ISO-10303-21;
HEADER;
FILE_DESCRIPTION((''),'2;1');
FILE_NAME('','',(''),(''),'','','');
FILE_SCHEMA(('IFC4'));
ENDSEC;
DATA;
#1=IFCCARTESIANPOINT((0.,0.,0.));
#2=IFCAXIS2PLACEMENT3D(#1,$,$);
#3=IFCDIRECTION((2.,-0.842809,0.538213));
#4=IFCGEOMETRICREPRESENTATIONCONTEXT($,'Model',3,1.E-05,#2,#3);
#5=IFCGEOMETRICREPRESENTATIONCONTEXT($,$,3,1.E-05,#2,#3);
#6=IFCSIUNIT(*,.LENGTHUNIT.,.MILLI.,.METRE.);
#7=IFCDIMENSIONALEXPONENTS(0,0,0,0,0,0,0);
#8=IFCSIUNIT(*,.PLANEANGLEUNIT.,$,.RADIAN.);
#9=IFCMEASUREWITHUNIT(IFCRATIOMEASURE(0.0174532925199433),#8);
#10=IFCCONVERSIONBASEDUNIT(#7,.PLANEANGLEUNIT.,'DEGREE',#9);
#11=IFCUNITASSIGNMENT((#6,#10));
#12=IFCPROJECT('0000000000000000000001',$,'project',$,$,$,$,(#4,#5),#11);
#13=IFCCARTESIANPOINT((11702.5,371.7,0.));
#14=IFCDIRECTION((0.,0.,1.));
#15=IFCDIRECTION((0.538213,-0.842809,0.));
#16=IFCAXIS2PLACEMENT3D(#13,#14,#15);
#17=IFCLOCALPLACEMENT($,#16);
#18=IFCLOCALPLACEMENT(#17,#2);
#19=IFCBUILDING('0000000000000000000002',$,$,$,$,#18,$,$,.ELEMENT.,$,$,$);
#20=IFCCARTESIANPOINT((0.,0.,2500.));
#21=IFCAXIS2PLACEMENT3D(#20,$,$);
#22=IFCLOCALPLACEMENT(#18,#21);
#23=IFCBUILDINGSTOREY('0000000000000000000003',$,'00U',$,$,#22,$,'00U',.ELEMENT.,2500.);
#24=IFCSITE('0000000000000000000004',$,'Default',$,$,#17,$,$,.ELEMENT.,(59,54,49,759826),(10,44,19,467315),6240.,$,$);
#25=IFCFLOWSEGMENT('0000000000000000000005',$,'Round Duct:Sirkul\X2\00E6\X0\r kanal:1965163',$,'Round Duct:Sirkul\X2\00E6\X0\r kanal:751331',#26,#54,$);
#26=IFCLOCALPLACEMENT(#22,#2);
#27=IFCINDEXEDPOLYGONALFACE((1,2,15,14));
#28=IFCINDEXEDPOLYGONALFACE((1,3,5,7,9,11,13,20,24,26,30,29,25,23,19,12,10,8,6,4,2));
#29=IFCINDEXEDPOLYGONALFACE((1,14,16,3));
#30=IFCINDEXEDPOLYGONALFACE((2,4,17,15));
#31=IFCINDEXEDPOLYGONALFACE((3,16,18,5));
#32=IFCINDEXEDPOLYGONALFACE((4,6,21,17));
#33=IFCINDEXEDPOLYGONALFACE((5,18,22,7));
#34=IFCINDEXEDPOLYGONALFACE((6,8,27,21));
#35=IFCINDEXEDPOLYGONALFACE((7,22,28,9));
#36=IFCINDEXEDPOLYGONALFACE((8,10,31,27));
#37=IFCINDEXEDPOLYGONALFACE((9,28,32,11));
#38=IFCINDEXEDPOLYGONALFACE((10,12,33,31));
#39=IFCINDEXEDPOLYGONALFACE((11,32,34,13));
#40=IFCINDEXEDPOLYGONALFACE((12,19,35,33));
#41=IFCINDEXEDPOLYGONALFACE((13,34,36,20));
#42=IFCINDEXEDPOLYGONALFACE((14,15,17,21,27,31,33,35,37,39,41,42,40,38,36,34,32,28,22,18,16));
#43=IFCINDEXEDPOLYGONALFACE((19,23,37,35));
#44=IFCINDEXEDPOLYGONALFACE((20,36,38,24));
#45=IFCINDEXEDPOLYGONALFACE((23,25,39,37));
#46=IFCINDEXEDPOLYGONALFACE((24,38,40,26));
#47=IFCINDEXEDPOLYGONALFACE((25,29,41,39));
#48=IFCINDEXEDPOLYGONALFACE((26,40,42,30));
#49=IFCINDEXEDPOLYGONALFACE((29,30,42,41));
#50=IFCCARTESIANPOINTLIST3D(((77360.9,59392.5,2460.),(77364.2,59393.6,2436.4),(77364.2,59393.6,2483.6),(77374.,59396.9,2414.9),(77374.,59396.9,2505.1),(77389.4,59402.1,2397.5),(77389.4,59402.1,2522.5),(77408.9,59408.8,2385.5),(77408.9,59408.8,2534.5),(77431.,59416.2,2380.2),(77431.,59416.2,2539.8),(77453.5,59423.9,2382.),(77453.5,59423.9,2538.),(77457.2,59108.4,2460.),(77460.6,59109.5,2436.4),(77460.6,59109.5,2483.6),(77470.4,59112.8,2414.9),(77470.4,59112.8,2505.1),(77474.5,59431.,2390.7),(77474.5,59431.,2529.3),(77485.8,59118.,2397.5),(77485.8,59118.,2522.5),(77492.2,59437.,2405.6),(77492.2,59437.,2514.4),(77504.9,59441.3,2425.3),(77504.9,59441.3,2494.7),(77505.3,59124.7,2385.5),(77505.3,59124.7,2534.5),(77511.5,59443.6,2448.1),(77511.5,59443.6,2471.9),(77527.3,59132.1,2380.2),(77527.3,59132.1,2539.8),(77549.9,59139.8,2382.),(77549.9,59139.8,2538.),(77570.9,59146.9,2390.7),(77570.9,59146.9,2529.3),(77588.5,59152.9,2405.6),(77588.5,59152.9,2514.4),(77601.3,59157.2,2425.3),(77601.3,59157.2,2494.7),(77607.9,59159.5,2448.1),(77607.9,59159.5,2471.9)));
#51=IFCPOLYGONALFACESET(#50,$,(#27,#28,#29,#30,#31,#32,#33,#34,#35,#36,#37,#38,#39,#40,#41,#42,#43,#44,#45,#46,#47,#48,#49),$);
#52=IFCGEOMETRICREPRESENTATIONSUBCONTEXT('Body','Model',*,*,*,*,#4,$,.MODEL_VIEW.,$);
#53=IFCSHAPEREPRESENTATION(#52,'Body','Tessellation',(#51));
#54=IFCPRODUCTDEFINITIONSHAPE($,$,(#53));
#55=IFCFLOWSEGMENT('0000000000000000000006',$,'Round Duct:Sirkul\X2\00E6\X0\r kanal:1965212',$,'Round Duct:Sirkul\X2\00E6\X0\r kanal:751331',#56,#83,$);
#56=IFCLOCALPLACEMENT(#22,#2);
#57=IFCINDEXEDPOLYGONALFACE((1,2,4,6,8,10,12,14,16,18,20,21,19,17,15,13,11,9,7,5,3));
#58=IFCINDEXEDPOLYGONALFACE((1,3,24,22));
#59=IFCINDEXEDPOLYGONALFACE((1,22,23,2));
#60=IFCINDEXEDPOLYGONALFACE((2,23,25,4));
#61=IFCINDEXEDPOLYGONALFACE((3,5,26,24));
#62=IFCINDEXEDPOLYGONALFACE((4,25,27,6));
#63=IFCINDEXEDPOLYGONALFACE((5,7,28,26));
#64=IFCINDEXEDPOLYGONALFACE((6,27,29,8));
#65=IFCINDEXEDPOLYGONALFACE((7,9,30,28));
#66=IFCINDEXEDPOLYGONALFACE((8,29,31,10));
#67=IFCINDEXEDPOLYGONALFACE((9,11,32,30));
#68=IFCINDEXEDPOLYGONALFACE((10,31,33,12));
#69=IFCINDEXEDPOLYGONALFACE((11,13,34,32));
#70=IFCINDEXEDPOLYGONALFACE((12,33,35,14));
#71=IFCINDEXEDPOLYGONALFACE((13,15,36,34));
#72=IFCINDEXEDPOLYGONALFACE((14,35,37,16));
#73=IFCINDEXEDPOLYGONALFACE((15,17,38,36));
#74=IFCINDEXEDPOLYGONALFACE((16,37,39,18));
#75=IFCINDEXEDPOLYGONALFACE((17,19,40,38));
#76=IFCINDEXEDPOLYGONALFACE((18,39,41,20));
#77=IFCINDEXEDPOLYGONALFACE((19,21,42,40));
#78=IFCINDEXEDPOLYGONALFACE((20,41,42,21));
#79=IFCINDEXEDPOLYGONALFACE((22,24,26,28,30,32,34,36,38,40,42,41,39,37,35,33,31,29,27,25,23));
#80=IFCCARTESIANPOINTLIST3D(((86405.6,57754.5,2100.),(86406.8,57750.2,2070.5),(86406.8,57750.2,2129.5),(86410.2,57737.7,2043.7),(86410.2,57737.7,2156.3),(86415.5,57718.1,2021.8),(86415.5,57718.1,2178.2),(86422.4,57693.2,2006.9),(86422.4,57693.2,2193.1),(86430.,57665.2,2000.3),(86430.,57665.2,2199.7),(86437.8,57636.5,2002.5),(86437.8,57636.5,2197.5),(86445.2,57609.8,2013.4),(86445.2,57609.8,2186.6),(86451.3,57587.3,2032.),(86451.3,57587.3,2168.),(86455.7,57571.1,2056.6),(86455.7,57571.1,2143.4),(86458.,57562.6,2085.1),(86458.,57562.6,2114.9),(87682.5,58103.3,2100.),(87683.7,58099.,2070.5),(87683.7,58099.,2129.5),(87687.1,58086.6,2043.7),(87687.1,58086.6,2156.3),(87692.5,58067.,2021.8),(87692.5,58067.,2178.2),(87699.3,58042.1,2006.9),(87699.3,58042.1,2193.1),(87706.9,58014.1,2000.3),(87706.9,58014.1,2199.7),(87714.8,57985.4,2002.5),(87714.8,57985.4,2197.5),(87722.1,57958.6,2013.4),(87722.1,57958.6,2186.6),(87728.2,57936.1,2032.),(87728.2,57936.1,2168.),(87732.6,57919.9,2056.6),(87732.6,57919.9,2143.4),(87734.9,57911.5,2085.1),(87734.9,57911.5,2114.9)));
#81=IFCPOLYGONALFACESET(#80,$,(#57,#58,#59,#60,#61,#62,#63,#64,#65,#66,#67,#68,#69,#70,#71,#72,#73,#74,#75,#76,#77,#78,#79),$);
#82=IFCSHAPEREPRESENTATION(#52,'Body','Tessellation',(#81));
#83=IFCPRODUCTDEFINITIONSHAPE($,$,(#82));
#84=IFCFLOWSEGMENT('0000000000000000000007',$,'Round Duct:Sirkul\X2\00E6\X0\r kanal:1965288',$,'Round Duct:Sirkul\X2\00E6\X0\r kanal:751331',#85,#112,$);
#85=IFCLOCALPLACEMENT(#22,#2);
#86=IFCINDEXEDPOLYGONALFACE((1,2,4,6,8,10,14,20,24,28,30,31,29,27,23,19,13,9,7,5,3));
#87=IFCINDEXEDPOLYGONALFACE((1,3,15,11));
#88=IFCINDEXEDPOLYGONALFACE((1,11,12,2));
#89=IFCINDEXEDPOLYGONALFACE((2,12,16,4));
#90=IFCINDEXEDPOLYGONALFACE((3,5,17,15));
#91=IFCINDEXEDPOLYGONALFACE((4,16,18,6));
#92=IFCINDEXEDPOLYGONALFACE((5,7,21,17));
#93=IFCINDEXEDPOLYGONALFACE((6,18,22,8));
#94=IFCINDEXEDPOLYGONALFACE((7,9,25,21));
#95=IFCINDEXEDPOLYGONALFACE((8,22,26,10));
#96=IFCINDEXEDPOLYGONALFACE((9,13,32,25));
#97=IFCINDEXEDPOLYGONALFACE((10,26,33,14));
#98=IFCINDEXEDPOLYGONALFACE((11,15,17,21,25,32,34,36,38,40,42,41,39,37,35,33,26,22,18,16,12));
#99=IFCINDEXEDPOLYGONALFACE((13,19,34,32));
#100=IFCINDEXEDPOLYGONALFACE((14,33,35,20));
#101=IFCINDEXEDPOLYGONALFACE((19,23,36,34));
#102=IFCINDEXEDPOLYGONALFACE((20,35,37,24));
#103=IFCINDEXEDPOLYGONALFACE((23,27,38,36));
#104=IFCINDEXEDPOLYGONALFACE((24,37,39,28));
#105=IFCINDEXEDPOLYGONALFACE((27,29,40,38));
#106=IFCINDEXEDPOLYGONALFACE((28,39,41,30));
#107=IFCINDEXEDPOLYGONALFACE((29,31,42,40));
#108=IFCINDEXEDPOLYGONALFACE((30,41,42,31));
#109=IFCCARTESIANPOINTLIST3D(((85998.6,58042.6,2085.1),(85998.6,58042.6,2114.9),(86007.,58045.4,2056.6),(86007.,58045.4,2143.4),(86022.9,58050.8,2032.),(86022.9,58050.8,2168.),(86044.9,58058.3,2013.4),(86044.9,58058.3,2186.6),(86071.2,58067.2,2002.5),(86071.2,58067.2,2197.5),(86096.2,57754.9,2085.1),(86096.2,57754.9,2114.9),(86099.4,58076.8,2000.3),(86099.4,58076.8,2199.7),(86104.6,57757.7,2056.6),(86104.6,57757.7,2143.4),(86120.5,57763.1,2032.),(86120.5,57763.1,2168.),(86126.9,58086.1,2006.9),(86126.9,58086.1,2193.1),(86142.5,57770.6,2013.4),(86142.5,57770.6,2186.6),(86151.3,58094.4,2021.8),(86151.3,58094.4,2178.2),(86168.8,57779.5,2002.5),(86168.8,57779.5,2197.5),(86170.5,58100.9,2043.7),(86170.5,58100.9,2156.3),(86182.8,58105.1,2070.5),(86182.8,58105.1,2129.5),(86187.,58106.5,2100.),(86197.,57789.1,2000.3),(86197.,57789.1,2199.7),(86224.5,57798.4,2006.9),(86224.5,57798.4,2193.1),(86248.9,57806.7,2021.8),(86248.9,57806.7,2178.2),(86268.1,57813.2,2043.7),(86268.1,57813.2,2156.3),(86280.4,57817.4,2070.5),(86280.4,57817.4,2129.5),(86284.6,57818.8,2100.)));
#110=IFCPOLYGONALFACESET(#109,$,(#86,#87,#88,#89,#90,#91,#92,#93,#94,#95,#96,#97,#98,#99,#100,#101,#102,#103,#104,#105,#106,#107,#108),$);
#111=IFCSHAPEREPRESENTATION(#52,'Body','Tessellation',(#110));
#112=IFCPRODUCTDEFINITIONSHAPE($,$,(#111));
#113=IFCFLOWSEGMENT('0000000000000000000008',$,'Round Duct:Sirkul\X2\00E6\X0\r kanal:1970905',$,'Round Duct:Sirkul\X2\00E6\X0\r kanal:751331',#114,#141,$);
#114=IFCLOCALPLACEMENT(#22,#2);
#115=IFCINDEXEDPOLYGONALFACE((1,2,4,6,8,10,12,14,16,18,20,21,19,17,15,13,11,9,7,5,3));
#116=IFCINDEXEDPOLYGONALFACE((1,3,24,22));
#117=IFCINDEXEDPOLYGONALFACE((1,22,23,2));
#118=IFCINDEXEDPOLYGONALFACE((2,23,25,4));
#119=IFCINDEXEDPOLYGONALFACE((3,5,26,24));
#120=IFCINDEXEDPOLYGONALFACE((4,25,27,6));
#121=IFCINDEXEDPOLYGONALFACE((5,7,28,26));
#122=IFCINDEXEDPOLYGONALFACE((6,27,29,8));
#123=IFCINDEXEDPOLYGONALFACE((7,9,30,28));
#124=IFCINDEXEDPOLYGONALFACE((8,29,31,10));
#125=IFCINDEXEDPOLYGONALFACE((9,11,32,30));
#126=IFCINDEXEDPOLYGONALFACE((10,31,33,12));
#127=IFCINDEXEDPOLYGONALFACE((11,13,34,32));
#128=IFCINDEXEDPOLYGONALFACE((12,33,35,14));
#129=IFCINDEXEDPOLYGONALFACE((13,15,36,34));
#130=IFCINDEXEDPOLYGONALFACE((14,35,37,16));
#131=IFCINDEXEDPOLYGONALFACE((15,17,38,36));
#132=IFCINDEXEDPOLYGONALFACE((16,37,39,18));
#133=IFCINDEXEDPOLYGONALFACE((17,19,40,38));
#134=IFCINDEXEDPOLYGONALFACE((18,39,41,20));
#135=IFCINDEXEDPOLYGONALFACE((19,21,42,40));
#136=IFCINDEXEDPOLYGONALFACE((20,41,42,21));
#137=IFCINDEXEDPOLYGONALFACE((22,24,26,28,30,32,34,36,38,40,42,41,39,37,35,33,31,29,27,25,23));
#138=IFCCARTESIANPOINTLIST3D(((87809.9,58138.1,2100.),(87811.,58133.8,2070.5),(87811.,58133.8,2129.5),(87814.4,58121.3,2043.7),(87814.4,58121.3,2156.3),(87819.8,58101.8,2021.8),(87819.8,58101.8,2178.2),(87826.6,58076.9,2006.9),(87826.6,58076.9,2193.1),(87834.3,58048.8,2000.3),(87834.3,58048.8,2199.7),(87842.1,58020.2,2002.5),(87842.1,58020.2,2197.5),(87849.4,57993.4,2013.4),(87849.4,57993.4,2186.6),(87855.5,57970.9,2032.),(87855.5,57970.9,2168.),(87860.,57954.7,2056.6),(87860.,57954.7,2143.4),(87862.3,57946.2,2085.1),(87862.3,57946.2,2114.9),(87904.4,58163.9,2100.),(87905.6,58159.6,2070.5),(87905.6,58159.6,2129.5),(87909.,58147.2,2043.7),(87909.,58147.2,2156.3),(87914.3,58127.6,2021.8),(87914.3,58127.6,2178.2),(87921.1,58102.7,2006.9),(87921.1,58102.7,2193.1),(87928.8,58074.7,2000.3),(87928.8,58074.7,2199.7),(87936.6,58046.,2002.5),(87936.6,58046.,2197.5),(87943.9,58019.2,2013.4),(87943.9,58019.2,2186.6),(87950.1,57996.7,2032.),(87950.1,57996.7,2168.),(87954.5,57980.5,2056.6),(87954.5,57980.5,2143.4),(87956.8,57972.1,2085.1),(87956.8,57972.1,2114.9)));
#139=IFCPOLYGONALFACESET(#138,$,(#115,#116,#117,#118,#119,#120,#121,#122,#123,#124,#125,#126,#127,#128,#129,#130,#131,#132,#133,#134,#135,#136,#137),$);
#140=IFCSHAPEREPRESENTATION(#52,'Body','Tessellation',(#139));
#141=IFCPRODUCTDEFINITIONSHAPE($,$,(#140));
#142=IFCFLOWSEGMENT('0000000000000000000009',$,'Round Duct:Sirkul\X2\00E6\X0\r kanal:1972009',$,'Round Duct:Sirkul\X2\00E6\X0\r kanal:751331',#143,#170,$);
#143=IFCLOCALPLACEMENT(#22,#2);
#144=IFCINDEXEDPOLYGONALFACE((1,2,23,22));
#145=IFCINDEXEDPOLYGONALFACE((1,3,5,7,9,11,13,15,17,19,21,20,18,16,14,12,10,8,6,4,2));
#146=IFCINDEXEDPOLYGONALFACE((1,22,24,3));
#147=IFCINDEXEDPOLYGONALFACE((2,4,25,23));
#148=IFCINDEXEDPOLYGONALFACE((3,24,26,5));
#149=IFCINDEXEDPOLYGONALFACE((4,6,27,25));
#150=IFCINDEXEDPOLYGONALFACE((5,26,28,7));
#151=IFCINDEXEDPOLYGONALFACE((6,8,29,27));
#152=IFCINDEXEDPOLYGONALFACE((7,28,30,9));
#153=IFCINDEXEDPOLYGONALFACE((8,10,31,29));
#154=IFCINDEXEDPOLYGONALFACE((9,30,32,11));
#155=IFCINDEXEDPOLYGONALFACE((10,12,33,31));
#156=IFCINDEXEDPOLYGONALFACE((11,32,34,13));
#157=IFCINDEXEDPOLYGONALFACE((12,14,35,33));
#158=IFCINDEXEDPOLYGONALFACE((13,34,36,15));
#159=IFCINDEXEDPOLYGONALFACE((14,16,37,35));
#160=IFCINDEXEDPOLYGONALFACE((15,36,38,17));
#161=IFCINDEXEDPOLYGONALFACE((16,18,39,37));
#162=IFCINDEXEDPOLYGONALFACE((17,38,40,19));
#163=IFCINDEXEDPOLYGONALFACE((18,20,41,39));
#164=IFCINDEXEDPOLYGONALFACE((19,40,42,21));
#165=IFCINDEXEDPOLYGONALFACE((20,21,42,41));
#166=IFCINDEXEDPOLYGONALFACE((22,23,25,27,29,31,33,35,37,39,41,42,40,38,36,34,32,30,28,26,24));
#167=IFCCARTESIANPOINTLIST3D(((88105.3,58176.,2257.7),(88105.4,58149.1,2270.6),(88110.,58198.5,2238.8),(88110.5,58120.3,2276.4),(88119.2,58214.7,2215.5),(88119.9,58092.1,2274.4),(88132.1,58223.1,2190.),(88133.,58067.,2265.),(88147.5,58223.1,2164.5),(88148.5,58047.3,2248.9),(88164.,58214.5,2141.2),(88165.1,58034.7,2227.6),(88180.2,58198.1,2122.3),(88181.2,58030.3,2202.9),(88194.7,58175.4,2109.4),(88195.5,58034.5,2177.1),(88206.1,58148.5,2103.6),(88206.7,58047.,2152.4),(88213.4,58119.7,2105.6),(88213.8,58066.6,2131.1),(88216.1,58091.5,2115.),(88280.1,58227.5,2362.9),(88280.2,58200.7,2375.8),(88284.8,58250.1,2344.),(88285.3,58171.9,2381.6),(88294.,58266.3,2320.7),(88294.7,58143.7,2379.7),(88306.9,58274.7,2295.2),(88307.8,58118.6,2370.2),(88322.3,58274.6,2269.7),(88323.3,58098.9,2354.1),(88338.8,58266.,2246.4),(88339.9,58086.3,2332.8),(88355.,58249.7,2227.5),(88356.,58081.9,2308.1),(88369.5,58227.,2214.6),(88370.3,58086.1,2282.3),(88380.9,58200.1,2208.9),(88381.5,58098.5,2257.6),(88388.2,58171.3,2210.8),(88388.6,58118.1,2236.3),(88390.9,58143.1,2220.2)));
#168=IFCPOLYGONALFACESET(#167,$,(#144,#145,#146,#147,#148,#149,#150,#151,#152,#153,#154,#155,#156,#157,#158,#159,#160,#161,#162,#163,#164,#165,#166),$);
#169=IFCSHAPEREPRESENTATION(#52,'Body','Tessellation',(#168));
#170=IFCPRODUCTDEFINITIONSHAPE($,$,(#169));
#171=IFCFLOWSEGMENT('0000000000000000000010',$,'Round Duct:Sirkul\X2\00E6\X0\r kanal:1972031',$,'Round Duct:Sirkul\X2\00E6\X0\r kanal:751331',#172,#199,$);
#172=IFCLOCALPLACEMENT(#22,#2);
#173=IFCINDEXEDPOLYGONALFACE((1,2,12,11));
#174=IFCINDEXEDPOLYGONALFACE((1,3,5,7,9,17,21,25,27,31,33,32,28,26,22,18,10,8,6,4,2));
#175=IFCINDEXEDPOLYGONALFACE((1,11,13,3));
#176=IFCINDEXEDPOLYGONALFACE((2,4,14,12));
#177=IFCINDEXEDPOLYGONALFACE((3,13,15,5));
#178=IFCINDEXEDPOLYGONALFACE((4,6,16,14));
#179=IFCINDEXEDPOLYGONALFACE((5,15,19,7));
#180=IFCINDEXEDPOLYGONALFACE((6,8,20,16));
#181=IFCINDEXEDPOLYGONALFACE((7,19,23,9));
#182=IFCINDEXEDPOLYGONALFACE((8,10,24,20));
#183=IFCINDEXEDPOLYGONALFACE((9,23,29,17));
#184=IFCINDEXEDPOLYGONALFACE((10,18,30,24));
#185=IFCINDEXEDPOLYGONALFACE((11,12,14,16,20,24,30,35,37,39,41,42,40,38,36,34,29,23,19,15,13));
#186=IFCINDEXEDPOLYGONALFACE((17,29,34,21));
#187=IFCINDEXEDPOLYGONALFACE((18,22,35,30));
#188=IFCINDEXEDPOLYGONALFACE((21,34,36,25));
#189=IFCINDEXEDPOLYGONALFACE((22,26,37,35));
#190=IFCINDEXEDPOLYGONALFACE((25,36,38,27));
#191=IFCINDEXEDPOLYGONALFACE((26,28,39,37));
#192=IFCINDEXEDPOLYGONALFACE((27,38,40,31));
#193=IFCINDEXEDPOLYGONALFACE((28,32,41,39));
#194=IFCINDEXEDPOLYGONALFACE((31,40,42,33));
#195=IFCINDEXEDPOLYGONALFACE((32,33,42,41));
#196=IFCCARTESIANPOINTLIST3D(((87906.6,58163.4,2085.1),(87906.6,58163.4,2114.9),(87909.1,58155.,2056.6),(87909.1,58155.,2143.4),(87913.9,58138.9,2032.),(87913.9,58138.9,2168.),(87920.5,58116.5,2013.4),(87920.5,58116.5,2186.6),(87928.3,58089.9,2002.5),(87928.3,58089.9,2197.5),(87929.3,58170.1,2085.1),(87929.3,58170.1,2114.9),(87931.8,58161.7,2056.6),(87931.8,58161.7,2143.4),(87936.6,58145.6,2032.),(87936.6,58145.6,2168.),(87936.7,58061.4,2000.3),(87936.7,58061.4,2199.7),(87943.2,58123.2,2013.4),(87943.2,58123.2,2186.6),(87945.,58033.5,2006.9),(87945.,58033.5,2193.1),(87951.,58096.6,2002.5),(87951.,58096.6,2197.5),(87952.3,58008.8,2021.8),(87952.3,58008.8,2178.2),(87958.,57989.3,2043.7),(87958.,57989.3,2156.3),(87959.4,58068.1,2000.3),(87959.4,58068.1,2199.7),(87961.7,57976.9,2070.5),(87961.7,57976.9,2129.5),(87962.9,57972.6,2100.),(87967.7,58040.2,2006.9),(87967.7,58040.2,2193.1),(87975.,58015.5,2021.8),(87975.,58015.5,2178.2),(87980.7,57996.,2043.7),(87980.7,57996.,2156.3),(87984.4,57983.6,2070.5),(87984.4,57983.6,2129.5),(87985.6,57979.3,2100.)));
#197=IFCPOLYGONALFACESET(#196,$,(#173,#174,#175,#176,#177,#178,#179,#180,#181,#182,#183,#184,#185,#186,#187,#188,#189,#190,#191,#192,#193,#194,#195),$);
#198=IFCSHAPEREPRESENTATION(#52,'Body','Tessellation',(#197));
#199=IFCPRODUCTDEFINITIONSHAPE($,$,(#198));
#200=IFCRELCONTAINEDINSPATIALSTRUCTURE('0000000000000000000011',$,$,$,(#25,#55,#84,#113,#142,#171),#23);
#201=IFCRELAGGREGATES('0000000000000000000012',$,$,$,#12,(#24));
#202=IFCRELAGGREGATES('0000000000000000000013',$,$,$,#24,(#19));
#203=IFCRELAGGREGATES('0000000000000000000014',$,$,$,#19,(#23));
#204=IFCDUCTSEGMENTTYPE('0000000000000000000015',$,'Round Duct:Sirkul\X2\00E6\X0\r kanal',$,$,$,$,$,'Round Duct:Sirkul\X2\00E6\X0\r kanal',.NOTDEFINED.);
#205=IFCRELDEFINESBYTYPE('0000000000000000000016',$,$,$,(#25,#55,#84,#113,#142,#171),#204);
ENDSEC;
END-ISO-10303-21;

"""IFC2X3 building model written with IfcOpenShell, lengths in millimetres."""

from ifc_helpers import new_model, entity, si_unit, converted_unit, direction, frame, frame_2d, origin, origin_2d_with_axis, place, context, subcontext, project, spatial, circle, extrude, type_object, element, save


model = new_model("IFC2X3")

# Units and contexts
model_context = context("Model", 3, precision=1e-05, world=origin(), true_north=direction((2.0, -0.842809, 0.538213)))
context_of_model = context(None, 3, precision=1e-05, world=origin(), true_north=direction((2.0, -0.842809, 0.538213)))
body_context = subcontext(model_context, "Body", "Model", "MODEL_VIEW")
ifc_project = project(units=[si_unit("LENGTHUNIT", "METRE", prefix="MILLI"), converted_unit("PLANEANGLEUNIT", "DEGREE", entity("IfcRatioMeasure", 0.0174532925199433), si_unit("PLANEANGLEUNIT", "RADIAN"), dimensions=[0, 0, 0, 0, 0, 0, 0])], contexts=[model_context, context_of_model])

# Site, building, storey
site_placement = place(None, frame((11702.5, 371.7, 0.0), z_axis=(0.0, 0.0, 1.0), x_axis=(0.538213, -0.842809, 0.0)))
site = spatial("IfcSite", under=ifc_project, at=site_placement, Name="Default", CompositionType="ELEMENT", RefLatitude=(59, 54, 49, 759826), RefLongitude=(10, 44, 19, 467315), RefElevation=6240.0)
building_placement = place(site_placement, origin())
building = spatial("IfcBuilding", under=site, at=building_placement, CompositionType="ELEMENT")
storey_placement = place(building_placement, frame((0.0, 0.0, 2500.0)))
storey = spatial("IfcBuildingStorey", under=building, at=storey_placement, Name="00U", LongName="00U", CompositionType="ELEMENT", Elevation=2500.0)

# Flow segments
duct_segment_type_1 = type_object("IfcDuctSegmentType", Name="Round Duct:Sirkulær kanal", ElementType="Round Duct:Sirkulær kanal", PredefinedType="NOTDEFINED")
flow_segment_1_placement = place(storey_placement, origin())
element("IfcFlowSegment", 1, at=flow_segment_1_placement, inside=storey, type_object=duct_segment_type_1, Name="Round Duct:Sirkulær kanal:1965163", ObjectType="Round Duct:Sirkulær kanal:751331", context=body_context, shape_type="SweptSolid", body=[
    extrude(circle(Radius=80.0, at=origin_2d_with_axis()), frame((77436.6, 59418.2, 2460.0), z_axis=(0.321251, -0.946994, 0.0), x_axis=(-0.946994, -0.321251, 0.0)), (0.0, 0.0, 1.0), 300.0),
])
flow_segment_2_placement = place(storey_placement, origin())
element("IfcFlowSegment", 2, at=flow_segment_2_placement, inside=storey, type_object=duct_segment_type_1, Name="Round Duct:Sirkulær kanal:1965212", ObjectType="Round Duct:Sirkulær kanal:751331", context=body_context, shape_type="SweptSolid", body=[
    extrude(circle(Radius=100.0, at=origin_2d_with_axis()), frame((86432.0, 57658.0, 2100.0), z_axis=(0.964649, 0.263536, 0.0), x_axis=(-0.263536, 0.964649, 0.0)), (0.0, 0.0, 1.0), 1323.7),
])
flow_segment_3_placement = place(storey_placement, origin())
element("IfcFlowSegment", 3, at=flow_segment_3_placement, inside=storey, type_object=duct_segment_type_1, Name="Round Duct:Sirkulær kanal:1965288", ObjectType="Round Duct:Sirkulær kanal:751331", context=body_context, shape_type="SweptSolid", body=[
    extrude(circle(Radius=100.0, at=frame_2d((0.0, 0.0), x_axis=(1.0, 0.0))), frame((86092.3, 58074.4, 2100.0), z_axis=(0.321288, -0.946982, 0.0), x_axis=(0.946982, 0.321288, 0.0)), (0.0, 0.0, 1.0), 303.8),
])
flow_segment_4_placement = place(storey_placement, origin())
element("IfcFlowSegment", 4, at=flow_segment_4_placement, inside=storey, type_object=duct_segment_type_1, Name="Round Duct:Sirkulær kanal:1970905", ObjectType="Round Duct:Sirkulær kanal:751331", context=body_context, shape_type="SweptSolid", body=[
    extrude(circle(Radius=100.0, at=frame_2d((0.0, 0.0), x_axis=(1.0, 0.0))), frame((87836.2, 58041.6, 2100.0), z_axis=(0.964649, 0.263536, 0.0), x_axis=(-0.263536, 0.964649, 0.0)), (0.0, 0.0, 1.0), 98.0),
])
flow_segment_5_placement = place(storey_placement, origin())
element("IfcFlowSegment", 5, at=flow_segment_5_placement, inside=storey, type_object=duct_segment_type_1, Name="Round Duct:Sirkulær kanal:1972009", ObjectType="Round Duct:Sirkulær kanal:751331", context=body_context, shape_type="SweptSolid", body=[
    extrude(circle(Radius=100.0, at=frame_2d((0.0, 0.0), x_axis=(1.0, 0.0))), frame((88160.4, 58127.2, 2190.0), z_axis=(0.830628, 0.245064, 0.5), x_axis=(-0.282976, 0.959127, 0.0)), (0.0, 0.0, 1.0), 210.4),
])
flow_segment_6_placement = place(storey_placement, origin())
element("IfcFlowSegment", 6, at=flow_segment_6_placement, inside=storey, type_object=duct_segment_type_1, Name="Round Duct:Sirkulær kanal:1972031", ObjectType="Round Duct:Sirkulær kanal:751331", context=body_context, shape_type="SweptSolid", body=[
    extrude(circle(Radius=100.0, at=origin_2d_with_axis()), frame((87934.6, 58068.6, 2100.0), z_axis=(0.959127, 0.282976, 0.0), x_axis=(0.282976, -0.959127, 0.0)), (0.0, 0.0, 1.0), 23.7),
])

save(model, "model.ifc")
